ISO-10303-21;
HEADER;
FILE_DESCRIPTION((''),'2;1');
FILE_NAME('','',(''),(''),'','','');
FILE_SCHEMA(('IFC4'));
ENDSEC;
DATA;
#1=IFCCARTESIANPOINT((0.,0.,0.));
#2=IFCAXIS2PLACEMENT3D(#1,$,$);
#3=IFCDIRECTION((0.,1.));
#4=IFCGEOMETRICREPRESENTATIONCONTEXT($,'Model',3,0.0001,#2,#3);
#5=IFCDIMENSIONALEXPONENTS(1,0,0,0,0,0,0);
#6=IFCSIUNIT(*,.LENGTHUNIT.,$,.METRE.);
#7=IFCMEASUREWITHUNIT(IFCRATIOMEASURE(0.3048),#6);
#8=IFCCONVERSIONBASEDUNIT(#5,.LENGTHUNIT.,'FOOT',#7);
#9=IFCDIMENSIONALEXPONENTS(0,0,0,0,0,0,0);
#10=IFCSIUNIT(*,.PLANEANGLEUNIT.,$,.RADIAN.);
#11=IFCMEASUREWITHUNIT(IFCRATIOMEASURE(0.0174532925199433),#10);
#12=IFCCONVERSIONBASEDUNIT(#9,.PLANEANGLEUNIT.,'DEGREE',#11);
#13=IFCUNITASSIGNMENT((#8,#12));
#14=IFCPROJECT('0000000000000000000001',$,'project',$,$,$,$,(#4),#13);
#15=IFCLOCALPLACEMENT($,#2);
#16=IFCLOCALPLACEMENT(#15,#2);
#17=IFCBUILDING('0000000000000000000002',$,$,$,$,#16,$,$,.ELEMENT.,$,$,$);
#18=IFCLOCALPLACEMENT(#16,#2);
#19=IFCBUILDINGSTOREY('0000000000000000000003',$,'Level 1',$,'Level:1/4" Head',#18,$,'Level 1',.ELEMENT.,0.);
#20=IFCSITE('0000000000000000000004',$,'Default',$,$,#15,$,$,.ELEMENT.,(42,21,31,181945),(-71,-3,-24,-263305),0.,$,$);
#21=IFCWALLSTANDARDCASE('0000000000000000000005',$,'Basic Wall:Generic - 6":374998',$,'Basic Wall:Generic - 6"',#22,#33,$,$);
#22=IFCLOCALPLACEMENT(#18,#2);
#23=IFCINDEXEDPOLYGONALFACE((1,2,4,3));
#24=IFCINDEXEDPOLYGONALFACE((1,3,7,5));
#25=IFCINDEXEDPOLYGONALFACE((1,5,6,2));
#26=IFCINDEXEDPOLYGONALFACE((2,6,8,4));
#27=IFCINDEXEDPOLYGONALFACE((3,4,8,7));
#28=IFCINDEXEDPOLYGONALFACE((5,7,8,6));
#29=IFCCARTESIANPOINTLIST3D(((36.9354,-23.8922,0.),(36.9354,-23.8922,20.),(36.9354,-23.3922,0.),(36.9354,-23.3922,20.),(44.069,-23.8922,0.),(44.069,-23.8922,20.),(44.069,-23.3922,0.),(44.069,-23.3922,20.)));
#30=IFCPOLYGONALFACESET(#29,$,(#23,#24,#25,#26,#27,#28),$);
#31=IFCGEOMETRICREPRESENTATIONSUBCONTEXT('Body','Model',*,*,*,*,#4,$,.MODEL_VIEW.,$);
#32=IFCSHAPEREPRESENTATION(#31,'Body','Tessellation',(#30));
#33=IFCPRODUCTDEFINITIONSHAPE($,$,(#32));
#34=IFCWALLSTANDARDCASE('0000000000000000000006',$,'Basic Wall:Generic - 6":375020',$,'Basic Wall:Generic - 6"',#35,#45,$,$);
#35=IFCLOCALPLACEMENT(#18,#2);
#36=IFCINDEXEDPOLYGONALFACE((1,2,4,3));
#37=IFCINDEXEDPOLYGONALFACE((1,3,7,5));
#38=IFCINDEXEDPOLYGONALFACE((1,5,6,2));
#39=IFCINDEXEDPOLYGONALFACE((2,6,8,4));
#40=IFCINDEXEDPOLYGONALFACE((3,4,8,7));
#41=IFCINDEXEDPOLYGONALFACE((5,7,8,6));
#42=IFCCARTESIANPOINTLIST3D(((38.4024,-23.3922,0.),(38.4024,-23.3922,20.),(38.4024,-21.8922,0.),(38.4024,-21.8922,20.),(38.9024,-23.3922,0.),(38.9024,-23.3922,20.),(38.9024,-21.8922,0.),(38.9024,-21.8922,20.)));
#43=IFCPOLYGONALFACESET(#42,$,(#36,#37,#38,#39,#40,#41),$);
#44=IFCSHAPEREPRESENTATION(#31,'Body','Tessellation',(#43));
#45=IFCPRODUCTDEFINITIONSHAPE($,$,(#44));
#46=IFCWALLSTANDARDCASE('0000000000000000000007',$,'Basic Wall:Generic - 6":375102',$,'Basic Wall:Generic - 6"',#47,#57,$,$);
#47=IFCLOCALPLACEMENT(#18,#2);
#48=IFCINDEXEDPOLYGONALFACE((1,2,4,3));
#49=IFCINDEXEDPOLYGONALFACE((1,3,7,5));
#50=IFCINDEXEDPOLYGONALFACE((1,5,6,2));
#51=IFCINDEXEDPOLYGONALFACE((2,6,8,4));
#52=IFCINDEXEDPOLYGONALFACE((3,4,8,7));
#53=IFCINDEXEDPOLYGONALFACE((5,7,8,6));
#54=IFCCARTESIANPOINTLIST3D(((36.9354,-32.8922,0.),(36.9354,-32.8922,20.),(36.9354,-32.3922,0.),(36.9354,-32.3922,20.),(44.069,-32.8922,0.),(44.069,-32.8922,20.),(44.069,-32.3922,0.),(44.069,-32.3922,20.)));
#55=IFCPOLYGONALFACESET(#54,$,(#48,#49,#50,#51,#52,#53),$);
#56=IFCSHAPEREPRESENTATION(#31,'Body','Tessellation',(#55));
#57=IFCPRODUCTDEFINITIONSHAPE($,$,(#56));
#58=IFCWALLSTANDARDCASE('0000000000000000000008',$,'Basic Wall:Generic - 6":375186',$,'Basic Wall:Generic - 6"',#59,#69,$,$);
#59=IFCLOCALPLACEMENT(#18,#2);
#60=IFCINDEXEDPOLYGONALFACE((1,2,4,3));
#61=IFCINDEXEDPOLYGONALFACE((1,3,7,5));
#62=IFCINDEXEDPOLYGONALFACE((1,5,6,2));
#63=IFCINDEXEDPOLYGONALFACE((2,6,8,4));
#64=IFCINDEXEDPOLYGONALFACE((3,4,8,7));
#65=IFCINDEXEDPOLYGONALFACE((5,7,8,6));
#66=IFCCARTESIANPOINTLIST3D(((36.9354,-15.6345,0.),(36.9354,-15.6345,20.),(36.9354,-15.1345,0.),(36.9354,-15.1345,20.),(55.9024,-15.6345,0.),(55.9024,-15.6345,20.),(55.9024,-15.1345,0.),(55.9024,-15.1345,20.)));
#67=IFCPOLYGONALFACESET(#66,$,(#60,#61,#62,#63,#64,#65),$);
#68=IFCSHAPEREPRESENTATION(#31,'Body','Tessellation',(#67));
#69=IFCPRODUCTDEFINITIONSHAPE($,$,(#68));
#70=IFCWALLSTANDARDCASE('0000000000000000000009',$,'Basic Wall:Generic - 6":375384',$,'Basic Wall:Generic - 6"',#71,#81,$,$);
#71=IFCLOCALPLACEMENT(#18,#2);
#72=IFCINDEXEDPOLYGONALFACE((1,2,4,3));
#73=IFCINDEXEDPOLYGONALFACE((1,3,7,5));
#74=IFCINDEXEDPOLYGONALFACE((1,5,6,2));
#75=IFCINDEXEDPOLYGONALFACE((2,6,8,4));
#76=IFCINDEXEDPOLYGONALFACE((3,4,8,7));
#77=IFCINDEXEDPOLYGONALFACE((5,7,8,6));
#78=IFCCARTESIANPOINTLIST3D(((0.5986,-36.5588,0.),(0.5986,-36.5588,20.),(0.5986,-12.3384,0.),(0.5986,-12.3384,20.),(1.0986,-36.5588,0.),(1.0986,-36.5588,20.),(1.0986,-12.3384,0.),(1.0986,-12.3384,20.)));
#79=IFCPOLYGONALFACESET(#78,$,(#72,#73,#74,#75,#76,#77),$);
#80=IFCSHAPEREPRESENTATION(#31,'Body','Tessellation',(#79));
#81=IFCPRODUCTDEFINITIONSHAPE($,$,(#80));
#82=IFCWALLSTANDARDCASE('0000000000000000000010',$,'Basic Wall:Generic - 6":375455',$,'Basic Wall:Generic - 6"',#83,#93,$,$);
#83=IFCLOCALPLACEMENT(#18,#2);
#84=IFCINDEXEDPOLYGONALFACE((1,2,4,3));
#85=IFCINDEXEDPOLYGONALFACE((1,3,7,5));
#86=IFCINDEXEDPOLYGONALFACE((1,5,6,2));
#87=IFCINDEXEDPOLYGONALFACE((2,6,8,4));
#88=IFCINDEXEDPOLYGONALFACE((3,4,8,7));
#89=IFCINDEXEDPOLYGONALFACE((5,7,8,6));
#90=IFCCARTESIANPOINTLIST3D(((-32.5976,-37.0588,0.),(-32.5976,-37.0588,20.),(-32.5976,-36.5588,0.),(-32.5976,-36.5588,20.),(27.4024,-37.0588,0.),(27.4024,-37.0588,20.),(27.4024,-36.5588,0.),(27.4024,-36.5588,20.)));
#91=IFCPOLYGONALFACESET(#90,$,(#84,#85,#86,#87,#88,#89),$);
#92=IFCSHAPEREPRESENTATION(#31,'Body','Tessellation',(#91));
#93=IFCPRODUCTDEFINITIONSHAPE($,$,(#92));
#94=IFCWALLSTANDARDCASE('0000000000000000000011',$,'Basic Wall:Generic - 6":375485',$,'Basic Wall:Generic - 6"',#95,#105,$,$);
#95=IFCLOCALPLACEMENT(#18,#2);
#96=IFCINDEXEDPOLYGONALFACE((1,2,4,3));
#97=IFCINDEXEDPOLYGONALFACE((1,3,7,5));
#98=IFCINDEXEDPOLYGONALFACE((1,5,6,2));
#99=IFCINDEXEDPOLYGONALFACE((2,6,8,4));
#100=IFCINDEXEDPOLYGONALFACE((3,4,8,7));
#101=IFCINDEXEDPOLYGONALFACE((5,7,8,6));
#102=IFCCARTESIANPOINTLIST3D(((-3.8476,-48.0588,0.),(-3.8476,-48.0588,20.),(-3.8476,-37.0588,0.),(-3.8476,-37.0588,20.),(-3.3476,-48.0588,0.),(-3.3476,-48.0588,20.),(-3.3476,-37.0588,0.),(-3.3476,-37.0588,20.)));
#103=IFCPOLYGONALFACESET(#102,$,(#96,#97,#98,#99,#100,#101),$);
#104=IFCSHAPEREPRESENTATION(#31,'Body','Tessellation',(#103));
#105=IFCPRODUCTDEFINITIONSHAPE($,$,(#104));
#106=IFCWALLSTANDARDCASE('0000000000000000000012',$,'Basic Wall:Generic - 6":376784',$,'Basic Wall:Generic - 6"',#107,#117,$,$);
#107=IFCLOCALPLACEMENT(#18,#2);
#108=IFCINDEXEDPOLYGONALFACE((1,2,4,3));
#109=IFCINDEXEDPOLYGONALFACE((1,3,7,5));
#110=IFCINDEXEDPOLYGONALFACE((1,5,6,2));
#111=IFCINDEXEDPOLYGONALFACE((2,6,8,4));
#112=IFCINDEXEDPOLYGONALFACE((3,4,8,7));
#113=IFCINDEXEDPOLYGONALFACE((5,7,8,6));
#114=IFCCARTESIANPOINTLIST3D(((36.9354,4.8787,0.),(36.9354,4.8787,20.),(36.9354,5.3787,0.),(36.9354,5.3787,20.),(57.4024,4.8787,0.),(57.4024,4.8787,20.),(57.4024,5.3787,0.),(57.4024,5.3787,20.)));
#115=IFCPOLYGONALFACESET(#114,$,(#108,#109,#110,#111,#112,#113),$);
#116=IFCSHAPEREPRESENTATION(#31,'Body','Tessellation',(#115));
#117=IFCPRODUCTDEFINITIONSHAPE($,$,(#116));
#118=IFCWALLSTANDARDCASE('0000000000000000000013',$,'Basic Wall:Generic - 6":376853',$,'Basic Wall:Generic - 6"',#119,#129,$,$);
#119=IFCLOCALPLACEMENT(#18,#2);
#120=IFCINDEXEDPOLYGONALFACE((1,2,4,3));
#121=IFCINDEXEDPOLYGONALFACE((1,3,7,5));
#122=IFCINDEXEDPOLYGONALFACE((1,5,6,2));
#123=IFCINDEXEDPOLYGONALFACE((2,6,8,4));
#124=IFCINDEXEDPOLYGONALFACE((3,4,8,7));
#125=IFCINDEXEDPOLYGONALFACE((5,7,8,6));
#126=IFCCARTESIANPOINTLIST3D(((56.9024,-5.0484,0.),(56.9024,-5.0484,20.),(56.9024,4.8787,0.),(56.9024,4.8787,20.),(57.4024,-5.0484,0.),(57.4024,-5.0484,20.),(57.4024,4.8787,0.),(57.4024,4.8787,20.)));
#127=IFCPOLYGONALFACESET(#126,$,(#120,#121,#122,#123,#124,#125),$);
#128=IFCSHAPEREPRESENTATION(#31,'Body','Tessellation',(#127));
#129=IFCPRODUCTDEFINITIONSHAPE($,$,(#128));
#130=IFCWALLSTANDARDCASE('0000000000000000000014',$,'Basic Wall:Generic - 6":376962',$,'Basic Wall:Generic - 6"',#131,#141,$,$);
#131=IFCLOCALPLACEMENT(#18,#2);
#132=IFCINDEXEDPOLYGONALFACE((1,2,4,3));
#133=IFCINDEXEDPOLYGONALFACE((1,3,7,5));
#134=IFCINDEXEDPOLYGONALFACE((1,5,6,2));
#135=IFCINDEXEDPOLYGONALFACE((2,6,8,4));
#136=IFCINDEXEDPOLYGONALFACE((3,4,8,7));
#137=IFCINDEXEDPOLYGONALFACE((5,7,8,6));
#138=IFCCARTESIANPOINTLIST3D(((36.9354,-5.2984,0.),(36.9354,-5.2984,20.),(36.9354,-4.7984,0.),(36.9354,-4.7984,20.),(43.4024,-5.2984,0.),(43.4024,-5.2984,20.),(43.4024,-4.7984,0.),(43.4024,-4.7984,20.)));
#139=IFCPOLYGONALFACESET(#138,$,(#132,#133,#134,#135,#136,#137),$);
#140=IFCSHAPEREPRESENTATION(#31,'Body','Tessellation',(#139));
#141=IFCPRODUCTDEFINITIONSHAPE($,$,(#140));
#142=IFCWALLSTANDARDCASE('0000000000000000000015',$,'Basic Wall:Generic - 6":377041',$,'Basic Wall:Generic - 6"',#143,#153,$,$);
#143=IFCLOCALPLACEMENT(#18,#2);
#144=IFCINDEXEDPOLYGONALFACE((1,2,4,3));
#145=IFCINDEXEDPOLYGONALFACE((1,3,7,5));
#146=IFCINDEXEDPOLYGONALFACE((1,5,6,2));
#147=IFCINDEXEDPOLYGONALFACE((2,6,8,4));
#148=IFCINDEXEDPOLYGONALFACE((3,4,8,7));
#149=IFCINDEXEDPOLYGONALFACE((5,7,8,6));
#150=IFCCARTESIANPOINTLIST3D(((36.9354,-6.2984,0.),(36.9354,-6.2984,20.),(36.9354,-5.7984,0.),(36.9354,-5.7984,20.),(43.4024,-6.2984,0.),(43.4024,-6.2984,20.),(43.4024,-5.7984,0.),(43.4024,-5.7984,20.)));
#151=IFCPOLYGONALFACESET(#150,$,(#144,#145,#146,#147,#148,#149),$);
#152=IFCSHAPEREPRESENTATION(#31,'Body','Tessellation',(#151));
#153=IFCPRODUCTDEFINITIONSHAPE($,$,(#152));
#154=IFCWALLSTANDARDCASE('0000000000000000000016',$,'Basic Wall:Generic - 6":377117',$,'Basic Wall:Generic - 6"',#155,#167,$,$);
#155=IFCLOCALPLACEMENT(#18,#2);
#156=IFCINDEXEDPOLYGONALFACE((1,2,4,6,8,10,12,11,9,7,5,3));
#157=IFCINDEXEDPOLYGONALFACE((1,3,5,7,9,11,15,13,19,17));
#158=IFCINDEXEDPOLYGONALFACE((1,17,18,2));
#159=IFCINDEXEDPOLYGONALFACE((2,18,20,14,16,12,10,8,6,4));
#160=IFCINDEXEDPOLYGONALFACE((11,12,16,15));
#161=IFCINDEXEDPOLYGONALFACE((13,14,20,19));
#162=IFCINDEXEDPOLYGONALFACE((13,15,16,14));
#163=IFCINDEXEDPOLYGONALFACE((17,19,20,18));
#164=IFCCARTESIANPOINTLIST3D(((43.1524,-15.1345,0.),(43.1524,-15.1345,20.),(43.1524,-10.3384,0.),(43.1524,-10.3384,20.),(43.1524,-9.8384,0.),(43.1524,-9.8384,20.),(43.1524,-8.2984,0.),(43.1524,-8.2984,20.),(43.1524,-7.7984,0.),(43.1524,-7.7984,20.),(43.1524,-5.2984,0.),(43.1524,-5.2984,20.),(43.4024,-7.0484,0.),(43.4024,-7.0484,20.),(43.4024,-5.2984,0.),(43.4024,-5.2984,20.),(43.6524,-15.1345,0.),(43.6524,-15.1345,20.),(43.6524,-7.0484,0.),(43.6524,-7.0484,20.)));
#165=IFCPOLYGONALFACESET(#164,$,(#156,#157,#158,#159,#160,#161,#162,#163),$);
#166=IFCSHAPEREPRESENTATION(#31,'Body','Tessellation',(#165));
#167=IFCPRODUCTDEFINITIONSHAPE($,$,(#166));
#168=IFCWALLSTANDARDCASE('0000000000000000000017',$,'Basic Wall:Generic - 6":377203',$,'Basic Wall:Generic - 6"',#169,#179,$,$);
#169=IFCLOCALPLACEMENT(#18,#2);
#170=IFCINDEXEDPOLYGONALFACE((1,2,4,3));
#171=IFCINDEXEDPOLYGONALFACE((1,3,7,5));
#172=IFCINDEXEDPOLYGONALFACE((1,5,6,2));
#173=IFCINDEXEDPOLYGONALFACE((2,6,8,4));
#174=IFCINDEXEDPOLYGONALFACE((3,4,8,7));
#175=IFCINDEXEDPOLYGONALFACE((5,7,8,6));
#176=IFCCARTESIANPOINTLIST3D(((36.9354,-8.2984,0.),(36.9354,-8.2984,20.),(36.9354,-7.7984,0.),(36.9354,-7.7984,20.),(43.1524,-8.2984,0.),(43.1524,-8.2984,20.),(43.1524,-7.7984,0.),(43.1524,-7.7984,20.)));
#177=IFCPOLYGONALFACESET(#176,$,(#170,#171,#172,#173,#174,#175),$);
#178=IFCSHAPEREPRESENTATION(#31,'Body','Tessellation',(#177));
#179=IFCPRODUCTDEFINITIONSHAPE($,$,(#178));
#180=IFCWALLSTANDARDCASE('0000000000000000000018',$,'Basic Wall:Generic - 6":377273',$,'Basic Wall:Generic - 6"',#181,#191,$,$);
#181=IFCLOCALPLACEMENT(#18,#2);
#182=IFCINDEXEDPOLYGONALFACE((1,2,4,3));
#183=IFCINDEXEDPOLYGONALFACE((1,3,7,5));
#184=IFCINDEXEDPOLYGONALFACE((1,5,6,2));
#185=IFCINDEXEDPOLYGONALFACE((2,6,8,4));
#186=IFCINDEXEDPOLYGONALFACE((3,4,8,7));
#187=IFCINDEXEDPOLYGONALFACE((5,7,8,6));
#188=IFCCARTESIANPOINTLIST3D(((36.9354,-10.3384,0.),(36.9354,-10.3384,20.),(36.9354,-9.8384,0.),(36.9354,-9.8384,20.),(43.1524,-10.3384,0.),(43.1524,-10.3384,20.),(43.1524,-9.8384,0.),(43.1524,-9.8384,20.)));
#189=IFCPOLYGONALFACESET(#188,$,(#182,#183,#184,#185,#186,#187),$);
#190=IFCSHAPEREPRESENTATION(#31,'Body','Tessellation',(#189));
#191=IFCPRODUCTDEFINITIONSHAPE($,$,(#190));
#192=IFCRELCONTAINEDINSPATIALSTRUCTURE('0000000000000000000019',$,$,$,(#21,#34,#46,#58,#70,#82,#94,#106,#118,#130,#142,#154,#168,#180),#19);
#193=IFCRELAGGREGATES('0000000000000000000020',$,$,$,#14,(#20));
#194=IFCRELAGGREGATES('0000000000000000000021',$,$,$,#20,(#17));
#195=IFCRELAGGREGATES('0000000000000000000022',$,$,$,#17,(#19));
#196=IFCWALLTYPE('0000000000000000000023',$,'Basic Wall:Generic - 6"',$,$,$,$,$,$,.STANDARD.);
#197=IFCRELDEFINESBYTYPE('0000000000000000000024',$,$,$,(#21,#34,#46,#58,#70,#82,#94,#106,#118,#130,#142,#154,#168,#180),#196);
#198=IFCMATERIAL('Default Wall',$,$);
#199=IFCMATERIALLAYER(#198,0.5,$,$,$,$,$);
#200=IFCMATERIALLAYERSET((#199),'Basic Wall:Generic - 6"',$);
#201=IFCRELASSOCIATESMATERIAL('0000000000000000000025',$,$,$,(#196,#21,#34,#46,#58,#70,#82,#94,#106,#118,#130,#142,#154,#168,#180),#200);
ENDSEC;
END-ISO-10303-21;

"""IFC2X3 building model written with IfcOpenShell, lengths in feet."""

from ifc_helpers import new_model, entity, si_unit, converted_unit, direction, frame, frame_2d, origin, place, context, subcontext, project, spatial, polyline, rectangle, outline, extrude, material, layer, layer_set, layer_usage, type_object, element, save


model = new_model("IFC2X3")

# Units and contexts
model_context = context("Model", 3, precision=0.0001, world=origin(), true_north=direction((0.0, 1.0)))
body_context = subcontext(model_context, "Body", "Model", "MODEL_VIEW")
ifc_project = project(units=[converted_unit("LENGTHUNIT", "FOOT", entity("IfcRatioMeasure", 0.3048), si_unit("LENGTHUNIT", "METRE"), dimensions=[1, 0, 0, 0, 0, 0, 0]), converted_unit("PLANEANGLEUNIT", "DEGREE", entity("IfcRatioMeasure", 0.0174532925199433), si_unit("PLANEANGLEUNIT", "RADIAN"), dimensions=[0, 0, 0, 0, 0, 0, 0])], contexts=[model_context])

# Site, building, storey
site_placement = place(None, origin())
site = spatial("IfcSite", under=ifc_project, at=site_placement, Name="Default", CompositionType="ELEMENT", RefLatitude=(42, 21, 31, 181945), RefLongitude=(-71, -3, -24, -263305), RefElevation=0.0)
building_placement = place(site_placement, origin())
building = spatial("IfcBuilding", under=site, at=building_placement, CompositionType="ELEMENT")
storey_placement = place(building_placement, origin())
storey = spatial("IfcBuildingStorey", under=building, at=storey_placement, Name="Level 1", ObjectType="Level:1/4\" Head", LongName="Level 1", CompositionType="ELEMENT", Elevation=0.0)

# Walls
ifc_material = material(Name="Default Wall")
ifc_layer_1 = layer(ifc_material, 0.5)
ifc_layer_set_1 = layer_set([ifc_layer_1], Name="Basic Wall:Generic - 6\"")
wall_type_1 = type_object("IfcWallType", Name="Basic Wall:Generic - 6\"", PredefinedType="STANDARD", material=ifc_layer_set_1)
ifc_layer_usage_1 = layer_usage(ifc_layer_set_1, "AXIS2", "NEGATIVE", 0.25)
wall_1_placement = place(storey_placement, frame((44.069, -23.6422, 0.0), z_axis=(0.0, 0.0, 1.0), x_axis=(-1.0, 0.0, 0.0)))
element("IfcWallStandardCase", 1, at=wall_1_placement, inside=storey, type_object=wall_type_1, material=ifc_layer_usage_1, Name="Basic Wall:Generic - 6\":374998", ObjectType="Basic Wall:Generic - 6\"", context=body_context, shape_type="SweptSolid", body=[
    extrude(rectangle(XDim=7.1336, YDim=0.5, at=frame_2d((3.5668, 0.0), x_axis=(-1.0, 0.0))), origin(), (0.0, 0.0, 1.0), 20.0),
])
ifc_layer_usage_2 = layer_usage(ifc_layer_set_1, "AXIS2", "NEGATIVE", 0.25)
wall_2_placement = place(storey_placement, frame((38.6524, -21.8922, 0.0), z_axis=(0.0, 0.0, 1.0), x_axis=(0.0, -1.0, 0.0)))
element("IfcWallStandardCase", 2, at=wall_2_placement, inside=storey, type_object=wall_type_1, material=ifc_layer_usage_2, Name="Basic Wall:Generic - 6\":375020", ObjectType="Basic Wall:Generic - 6\"", context=body_context, shape_type="SweptSolid", body=[
    extrude(rectangle(XDim=1.5, YDim=0.5, at=frame_2d((0.75, 0.0), x_axis=(-1.0, 0.0))), origin(), (0.0, 0.0, 1.0), 20.0),
])
ifc_layer_usage_3 = layer_usage(ifc_layer_set_1, "AXIS2", "NEGATIVE", 0.25)
wall_3_placement = place(storey_placement, frame((36.9354, -32.6422, 0.0)))
element("IfcWallStandardCase", 3, at=wall_3_placement, inside=storey, type_object=wall_type_1, material=ifc_layer_usage_3, Name="Basic Wall:Generic - 6\":375102", ObjectType="Basic Wall:Generic - 6\"", context=body_context, shape_type="SweptSolid", body=[
    extrude(rectangle(XDim=7.1336, YDim=0.5, at=frame_2d((3.5668, 0.0), x_axis=(-1.0, 0.0))), origin(), (0.0, 0.0, 1.0), 20.0),
])
ifc_layer_usage_4 = layer_usage(ifc_layer_set_1, "AXIS2", "NEGATIVE", 0.25)
wall_4_placement = place(storey_placement, frame((36.9354, -15.3845, 0.0)))
element("IfcWallStandardCase", 4, at=wall_4_placement, inside=storey, type_object=wall_type_1, material=ifc_layer_usage_4, Name="Basic Wall:Generic - 6\":375186", ObjectType="Basic Wall:Generic - 6\"", context=body_context, shape_type="SweptSolid", body=[
    extrude(rectangle(XDim=18.9669, YDim=0.5, at=frame_2d((9.4835, 0.0), x_axis=(-1.0, 0.0))), origin(), (0.0, 0.0, 1.0), 20.0),
])
ifc_layer_usage_5 = layer_usage(ifc_layer_set_1, "AXIS2", "NEGATIVE", 0.25)
wall_5_placement = place(storey_placement, frame((0.8486, -12.3384, 0.0), z_axis=(0.0, 0.0, 1.0), x_axis=(0.0, -1.0, 0.0)))
element("IfcWallStandardCase", 5, at=wall_5_placement, inside=storey, type_object=wall_type_1, material=ifc_layer_usage_5, Name="Basic Wall:Generic - 6\":375384", ObjectType="Basic Wall:Generic - 6\"", context=body_context, shape_type="SweptSolid", body=[
    extrude(rectangle(XDim=24.2204, YDim=0.5, at=frame_2d((12.1102, 0.0), x_axis=(-1.0, 0.0))), origin(), (0.0, 0.0, 1.0), 20.0),
])
ifc_layer_usage_6 = layer_usage(ifc_layer_set_1, "AXIS2", "NEGATIVE", 0.25)
wall_6_placement = place(storey_placement, frame((27.4024, -36.8088, 0.0), z_axis=(0.0, 0.0, 1.0), x_axis=(-1.0, 0.0, 0.0)))
element("IfcWallStandardCase", 6, at=wall_6_placement, inside=storey, type_object=wall_type_1, material=ifc_layer_usage_6, Name="Basic Wall:Generic - 6\":375455", ObjectType="Basic Wall:Generic - 6\"", context=body_context, shape_type="SweptSolid", body=[
    extrude(rectangle(XDim=60.0, YDim=0.5, at=frame_2d((30.0, 0.0), x_axis=(-1.0, 0.0))), origin(), (0.0, 0.0, 1.0), 20.0),
])
ifc_layer_usage_7 = layer_usage(ifc_layer_set_1, "AXIS2", "NEGATIVE", 0.25)
wall_7_placement = place(storey_placement, frame((-3.5976, -48.0588, 0.0), z_axis=(0.0, 0.0, 1.0), x_axis=(0.0, 1.0, 0.0)))
element("IfcWallStandardCase", 7, at=wall_7_placement, inside=storey, type_object=wall_type_1, material=ifc_layer_usage_7, Name="Basic Wall:Generic - 6\":375485", ObjectType="Basic Wall:Generic - 6\"", context=body_context, shape_type="SweptSolid", body=[
    extrude(rectangle(XDim=11.0, YDim=0.5, at=frame_2d((5.5, 0.0), x_axis=(-1.0, 0.0))), origin(), (0.0, 0.0, 1.0), 20.0),
])
ifc_layer_usage_8 = layer_usage(ifc_layer_set_1, "AXIS2", "NEGATIVE", 0.25)
wall_8_placement = place(storey_placement, frame((36.9354, 5.1287, 0.0)))
element("IfcWallStandardCase", 8, at=wall_8_placement, inside=storey, type_object=wall_type_1, material=ifc_layer_usage_8, Name="Basic Wall:Generic - 6\":376784", ObjectType="Basic Wall:Generic - 6\"", context=body_context, shape_type="SweptSolid", body=[
    extrude(rectangle(XDim=20.4669, YDim=0.5, at=frame_2d((10.2335, 0.0), x_axis=(-1.0, 0.0))), origin(), (0.0, 0.0, 1.0), 20.0),
])
ifc_layer_usage_9 = layer_usage(ifc_layer_set_1, "AXIS2", "NEGATIVE", 0.25)
wall_9_placement = place(storey_placement, frame((57.1524, 4.8787, 0.0), z_axis=(0.0, 0.0, 1.0), x_axis=(0.0, -1.0, 0.0)))
element("IfcWallStandardCase", 9, at=wall_9_placement, inside=storey, type_object=wall_type_1, material=ifc_layer_usage_9, Name="Basic Wall:Generic - 6\":376853", ObjectType="Basic Wall:Generic - 6\"", context=body_context, shape_type="SweptSolid", body=[
    extrude(rectangle(XDim=9.9271, YDim=0.5, at=frame_2d((4.9635, 0.0), x_axis=(-1.0, 0.0))), origin(), (0.0, 0.0, 1.0), 20.0),
])
ifc_layer_usage_10 = layer_usage(ifc_layer_set_1, "AXIS2", "NEGATIVE", 0.25)
wall_10_placement = place(storey_placement, frame((36.9354, -5.0484, 0.0)))
element("IfcWallStandardCase", 10, at=wall_10_placement, inside=storey, type_object=wall_type_1, material=ifc_layer_usage_10, Name="Basic Wall:Generic - 6\":376962", ObjectType="Basic Wall:Generic - 6\"", context=body_context, shape_type="SweptSolid", body=[
    extrude(rectangle(XDim=6.4669, YDim=0.5, at=frame_2d((3.2335, 0.0), x_axis=(-1.0, 0.0))), origin(), (0.0, 0.0, 1.0), 20.0),
])
ifc_layer_usage_11 = layer_usage(ifc_layer_set_1, "AXIS2", "NEGATIVE", 0.25)
wall_11_placement = place(storey_placement, frame((36.9354, -6.0484, 0.0)))
element("IfcWallStandardCase", 11, at=wall_11_placement, inside=storey, type_object=wall_type_1, material=ifc_layer_usage_11, Name="Basic Wall:Generic - 6\":377041", ObjectType="Basic Wall:Generic - 6\"", context=body_context, shape_type="SweptSolid", body=[
    extrude(rectangle(XDim=6.4669, YDim=0.5, at=frame_2d((3.2335, 0.0), x_axis=(-1.0, 0.0))), origin(), (0.0, 0.0, 1.0), 20.0),
])
ifc_layer_usage_12 = layer_usage(ifc_layer_set_1, "AXIS2", "NEGATIVE", 0.25)
wall_12_placement = place(storey_placement, frame((43.4024, -15.1345, 0.0), z_axis=(0.0, 0.0, 1.0), x_axis=(0.0, 1.0, 0.0)))
element("IfcWallStandardCase", 12, at=wall_12_placement, inside=storey, type_object=wall_type_1, material=ifc_layer_usage_12, Name="Basic Wall:Generic - 6\":377117", ObjectType="Basic Wall:Generic - 6\"", context=body_context, shape_type="SweptSolid", body=[
    extrude(outline(polyline([(8.0861, -0.25), (8.0861, 0.0), (9.8361, 0.0), (9.8361, 0.25), (7.3361, 0.25), (6.8361, 0.25), (5.2961, 0.25), (4.7961, 0.25), (0.0, 0.25), (0.0, -0.25), (8.0861, -0.25)])), origin(), (0.0, 0.0, 1.0), 20.0),
])
ifc_layer_usage_13 = layer_usage(ifc_layer_set_1, "AXIS2", "NEGATIVE", 0.25)
wall_13_placement = place(storey_placement, frame((36.9354, -8.0484, 0.0)))
element("IfcWallStandardCase", 13, at=wall_13_placement, inside=storey, type_object=wall_type_1, material=ifc_layer_usage_13, Name="Basic Wall:Generic - 6\":377203", ObjectType="Basic Wall:Generic - 6\"", context=body_context, shape_type="SweptSolid", body=[
    extrude(rectangle(XDim=6.2169, YDim=0.5, at=frame_2d((3.1085, 0.0), x_axis=(-1.0, 0.0))), origin(), (0.0, 0.0, 1.0), 20.0),
])
ifc_layer_usage_14 = layer_usage(ifc_layer_set_1, "AXIS2", "NEGATIVE", 0.25)
wall_14_placement = place(storey_placement, frame((36.9354, -10.0884, 0.0)))
element("IfcWallStandardCase", 14, at=wall_14_placement, inside=storey, type_object=wall_type_1, material=ifc_layer_usage_14, Name="Basic Wall:Generic - 6\":377273", ObjectType="Basic Wall:Generic - 6\"", context=body_context, shape_type="SweptSolid", body=[
    extrude(rectangle(XDim=6.2169, YDim=0.5, at=frame_2d((3.1085, 0.0), x_axis=(-1.0, 0.0))), origin(), (0.0, 0.0, 1.0), 20.0),
])

save(model, "model.ifc")
